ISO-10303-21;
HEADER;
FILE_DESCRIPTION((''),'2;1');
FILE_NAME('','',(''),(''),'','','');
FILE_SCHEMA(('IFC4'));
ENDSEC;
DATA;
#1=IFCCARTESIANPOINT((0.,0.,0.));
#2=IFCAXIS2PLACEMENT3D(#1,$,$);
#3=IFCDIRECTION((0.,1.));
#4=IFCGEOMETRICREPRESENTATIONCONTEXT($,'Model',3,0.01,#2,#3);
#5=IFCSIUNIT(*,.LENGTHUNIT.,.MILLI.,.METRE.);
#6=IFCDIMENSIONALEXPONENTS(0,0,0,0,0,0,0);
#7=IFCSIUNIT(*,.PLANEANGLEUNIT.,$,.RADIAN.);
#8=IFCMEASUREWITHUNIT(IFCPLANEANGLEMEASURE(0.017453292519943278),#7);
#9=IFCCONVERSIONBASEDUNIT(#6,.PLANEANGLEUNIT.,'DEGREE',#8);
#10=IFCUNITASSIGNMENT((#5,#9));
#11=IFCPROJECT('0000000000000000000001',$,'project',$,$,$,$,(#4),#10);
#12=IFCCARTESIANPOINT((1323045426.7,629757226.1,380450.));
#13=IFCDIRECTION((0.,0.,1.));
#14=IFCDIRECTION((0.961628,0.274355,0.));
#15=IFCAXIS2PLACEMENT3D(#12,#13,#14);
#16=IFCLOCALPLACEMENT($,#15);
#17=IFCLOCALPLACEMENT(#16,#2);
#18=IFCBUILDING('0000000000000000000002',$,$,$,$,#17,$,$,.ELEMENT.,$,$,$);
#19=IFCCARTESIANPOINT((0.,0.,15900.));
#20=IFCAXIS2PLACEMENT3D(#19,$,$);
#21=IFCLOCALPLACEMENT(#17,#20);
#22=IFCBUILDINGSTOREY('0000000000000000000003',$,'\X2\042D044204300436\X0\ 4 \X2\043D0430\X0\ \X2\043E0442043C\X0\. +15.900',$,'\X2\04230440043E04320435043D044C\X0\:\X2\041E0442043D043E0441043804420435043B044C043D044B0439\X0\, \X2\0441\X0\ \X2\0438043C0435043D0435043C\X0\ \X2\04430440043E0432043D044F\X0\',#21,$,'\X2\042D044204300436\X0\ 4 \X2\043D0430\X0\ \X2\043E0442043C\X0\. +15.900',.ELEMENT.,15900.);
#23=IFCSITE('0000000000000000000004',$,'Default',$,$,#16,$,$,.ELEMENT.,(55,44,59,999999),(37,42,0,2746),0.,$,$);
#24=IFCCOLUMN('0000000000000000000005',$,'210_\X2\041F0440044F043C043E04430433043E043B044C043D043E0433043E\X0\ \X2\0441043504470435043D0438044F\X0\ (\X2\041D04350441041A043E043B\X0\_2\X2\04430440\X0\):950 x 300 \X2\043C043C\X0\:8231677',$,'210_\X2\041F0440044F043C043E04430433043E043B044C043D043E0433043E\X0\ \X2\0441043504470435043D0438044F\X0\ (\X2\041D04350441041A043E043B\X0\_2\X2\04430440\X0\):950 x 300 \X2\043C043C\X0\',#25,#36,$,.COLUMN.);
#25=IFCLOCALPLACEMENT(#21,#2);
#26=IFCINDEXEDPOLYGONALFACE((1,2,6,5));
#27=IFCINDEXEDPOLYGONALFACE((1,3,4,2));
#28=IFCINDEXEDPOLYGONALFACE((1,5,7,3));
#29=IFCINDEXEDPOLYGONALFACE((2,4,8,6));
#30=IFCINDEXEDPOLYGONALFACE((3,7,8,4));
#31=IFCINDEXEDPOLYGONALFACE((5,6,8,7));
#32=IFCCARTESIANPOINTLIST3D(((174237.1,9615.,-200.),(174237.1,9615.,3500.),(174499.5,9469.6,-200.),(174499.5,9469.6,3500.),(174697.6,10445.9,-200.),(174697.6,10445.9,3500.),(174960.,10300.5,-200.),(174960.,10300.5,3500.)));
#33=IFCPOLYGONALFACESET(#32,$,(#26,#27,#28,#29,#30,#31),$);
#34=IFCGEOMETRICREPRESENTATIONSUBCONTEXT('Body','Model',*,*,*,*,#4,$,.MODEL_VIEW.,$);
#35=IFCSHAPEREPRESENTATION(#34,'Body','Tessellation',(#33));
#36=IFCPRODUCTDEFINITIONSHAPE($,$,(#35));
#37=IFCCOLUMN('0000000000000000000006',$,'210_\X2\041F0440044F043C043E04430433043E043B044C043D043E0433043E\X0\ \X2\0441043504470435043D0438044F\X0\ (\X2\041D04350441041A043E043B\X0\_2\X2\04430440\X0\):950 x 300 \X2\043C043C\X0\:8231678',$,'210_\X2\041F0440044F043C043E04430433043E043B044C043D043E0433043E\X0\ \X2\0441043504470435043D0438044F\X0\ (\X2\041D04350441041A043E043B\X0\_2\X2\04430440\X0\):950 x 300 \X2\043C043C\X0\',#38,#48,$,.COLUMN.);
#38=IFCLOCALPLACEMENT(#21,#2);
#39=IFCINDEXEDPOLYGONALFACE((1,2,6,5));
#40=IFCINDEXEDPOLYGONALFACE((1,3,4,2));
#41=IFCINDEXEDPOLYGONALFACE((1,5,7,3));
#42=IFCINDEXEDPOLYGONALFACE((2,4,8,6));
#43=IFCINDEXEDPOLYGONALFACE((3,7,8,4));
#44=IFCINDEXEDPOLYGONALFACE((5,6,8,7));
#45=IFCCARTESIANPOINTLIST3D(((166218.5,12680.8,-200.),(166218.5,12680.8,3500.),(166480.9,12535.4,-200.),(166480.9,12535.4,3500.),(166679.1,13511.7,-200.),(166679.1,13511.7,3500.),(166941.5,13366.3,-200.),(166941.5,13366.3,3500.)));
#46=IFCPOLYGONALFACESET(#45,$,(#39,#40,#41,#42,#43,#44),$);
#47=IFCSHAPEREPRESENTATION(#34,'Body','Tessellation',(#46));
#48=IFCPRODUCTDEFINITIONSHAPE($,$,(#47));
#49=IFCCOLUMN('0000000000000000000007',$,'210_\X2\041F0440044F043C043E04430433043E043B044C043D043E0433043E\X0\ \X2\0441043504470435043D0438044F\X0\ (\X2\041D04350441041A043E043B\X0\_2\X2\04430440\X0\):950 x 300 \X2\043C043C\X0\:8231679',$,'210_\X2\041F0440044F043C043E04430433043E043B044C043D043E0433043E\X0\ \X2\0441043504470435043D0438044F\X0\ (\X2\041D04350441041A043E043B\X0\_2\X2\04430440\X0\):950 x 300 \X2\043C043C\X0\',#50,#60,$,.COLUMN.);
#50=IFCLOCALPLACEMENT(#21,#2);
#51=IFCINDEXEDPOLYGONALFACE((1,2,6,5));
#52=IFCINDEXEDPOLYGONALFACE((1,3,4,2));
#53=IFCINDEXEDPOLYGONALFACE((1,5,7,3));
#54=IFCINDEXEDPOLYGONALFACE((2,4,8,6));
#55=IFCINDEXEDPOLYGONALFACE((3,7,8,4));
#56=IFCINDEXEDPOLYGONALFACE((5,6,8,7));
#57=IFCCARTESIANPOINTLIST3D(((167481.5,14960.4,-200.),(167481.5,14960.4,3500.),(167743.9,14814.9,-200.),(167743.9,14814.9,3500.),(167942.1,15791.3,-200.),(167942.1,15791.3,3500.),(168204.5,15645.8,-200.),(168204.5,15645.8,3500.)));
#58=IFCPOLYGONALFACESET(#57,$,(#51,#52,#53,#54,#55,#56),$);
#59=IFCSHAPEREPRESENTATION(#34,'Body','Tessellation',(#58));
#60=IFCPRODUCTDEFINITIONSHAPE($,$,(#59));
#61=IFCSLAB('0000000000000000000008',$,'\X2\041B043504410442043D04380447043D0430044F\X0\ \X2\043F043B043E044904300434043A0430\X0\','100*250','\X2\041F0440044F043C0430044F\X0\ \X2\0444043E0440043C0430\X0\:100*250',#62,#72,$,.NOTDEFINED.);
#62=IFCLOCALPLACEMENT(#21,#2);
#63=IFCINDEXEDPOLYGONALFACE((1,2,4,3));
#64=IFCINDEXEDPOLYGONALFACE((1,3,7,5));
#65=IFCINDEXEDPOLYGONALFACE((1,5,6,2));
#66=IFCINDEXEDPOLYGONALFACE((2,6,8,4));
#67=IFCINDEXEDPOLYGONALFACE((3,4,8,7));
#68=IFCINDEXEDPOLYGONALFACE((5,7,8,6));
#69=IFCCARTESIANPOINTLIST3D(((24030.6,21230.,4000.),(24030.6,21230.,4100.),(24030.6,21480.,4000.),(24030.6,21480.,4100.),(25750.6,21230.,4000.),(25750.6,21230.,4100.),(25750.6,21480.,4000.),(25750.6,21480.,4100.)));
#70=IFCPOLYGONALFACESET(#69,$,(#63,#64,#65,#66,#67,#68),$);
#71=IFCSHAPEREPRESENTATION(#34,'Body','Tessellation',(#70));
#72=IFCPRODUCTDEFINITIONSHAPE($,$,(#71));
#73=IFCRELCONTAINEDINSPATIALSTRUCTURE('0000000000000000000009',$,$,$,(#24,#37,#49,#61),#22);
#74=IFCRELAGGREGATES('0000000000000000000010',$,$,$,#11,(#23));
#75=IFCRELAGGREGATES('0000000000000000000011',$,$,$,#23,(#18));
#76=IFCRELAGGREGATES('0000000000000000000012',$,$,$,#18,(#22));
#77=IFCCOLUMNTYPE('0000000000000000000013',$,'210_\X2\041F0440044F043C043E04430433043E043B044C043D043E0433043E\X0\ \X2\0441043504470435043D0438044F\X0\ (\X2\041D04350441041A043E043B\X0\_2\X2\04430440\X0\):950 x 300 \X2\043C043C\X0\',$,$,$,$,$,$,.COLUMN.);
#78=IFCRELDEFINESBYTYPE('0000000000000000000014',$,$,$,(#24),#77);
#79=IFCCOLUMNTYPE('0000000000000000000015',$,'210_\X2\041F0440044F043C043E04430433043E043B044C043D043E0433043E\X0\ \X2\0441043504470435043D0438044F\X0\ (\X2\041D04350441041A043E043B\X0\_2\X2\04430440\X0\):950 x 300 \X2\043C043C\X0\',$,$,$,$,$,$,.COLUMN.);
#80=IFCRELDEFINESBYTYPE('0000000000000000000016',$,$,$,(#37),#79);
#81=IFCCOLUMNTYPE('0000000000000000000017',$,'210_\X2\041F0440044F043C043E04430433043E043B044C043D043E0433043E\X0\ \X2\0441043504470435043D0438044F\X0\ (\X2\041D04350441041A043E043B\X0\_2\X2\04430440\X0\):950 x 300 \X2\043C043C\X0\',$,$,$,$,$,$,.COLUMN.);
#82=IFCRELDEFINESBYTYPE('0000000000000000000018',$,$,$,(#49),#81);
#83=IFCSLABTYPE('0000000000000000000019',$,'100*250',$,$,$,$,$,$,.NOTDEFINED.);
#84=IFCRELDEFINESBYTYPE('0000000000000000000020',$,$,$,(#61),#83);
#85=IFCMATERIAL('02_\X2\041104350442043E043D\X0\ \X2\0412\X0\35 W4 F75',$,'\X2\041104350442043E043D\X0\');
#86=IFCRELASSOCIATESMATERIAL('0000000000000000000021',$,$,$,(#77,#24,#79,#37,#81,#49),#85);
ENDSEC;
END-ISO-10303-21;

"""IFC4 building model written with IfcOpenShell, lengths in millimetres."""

from ifc_helpers import new_model, entity, si_unit, converted_unit, direction, frame, origin, place, context, subcontext, project, spatial, indexed_curve, outline, extrude, source, transform, mapped, material, type_object, type_shapes, element, save


model = new_model("IFC4")

# Units and contexts
model_context = context("Model", 3, precision=0.01, world=origin(), true_north=direction((0.0, 1.0)))
body_context = subcontext(model_context, "Body", "Model", "MODEL_VIEW")
ifc_project = project(units=[si_unit("LENGTHUNIT", "METRE", prefix="MILLI"), converted_unit("PLANEANGLEUNIT", "DEGREE", entity("IfcPlaneAngleMeasure", 0.017453292519943278), si_unit("PLANEANGLEUNIT", "RADIAN"), dimensions=[0, 0, 0, 0, 0, 0, 0])], contexts=[model_context])

# Site, building, storey
site_placement = place(None, frame((1323045426.7, 629757226.1, 380450.0), z_axis=(0.0, 0.0, 1.0), x_axis=(0.961628, 0.274355, 0.0)))
site = spatial("IfcSite", under=ifc_project, at=site_placement, Name="Default", CompositionType="ELEMENT", RefLatitude=(55, 44, 59, 999999), RefLongitude=(37, 42, 0, 2746), RefElevation=0.0)
building_placement = place(site_placement, origin())
building = spatial("IfcBuilding", under=site, at=building_placement, CompositionType="ELEMENT")
storey_placement = place(building_placement, frame((0.0, 0.0, 15900.0)))
storey = spatial("IfcBuildingStorey", under=building, at=storey_placement, Name="Этаж 4 на отм. +15.900", ObjectType="Уровень:Относительный, с именем уровня", LongName="Этаж 4 на отм. +15.900", CompositionType="ELEMENT", Elevation=15900.0)

# Columns
ifc_material_1 = material(Name="02_Бетон В35 W4 F75", Category="Бетон")
column_type_1 = type_object("IfcColumnType", Name="210_Прямоугольного сечения (НесКол_2ур):950 x 300 мм", PredefinedType="COLUMN", material=ifc_material_1)
shared_shape_1 = source(origin(), body_context, "Body", "SweptSolid", [
    extrude(outline(indexed_curve([(-150.0, -475.0), (150.0, -475.0), (150.0, 475.0), (-150.0, 475.0), (-150.0, -475.0)], self_intersect=False)), frame((174598.6, 9957.8, 15700.0), z_axis=(0.0, 0.0, 1.0), x_axis=(-0.87462, 0.48481, 0.0)), (0.0, 0.0, 1.0), 3700.0),
])
type_shapes(column_type_1, [shared_shape_1])
column_1_placement = place(storey_placement, frame((0.0, 0.0, -15900.0)))
element("IfcColumn", 1, at=column_1_placement, inside=storey, type_object=column_type_1, material=ifc_material_1, Name="210_Прямоугольного сечения (НесКол_2ур):950 x 300 мм:8231677", ObjectType="210_Прямоугольного сечения (НесКол_2ур):950 x 300 мм", PredefinedType="COLUMN", context=body_context, shape_type="MappedRepresentation", body=[
    mapped(shared_shape_1, transform((0.0, 0.0, 0.0), scale=1.0)),
])
column_type_2 = type_object("IfcColumnType", Name="210_Прямоугольного сечения (НесКол_2ур):950 x 300 мм", PredefinedType="COLUMN", material=ifc_material_1)
shared_shape_2 = source(origin(), body_context, "Body", "SweptSolid", [
    extrude(outline(indexed_curve([(-150.0, -475.0), (150.0, -475.0), (150.0, 475.0), (-150.0, 475.0), (-150.0, -475.0)], self_intersect=False)), frame((166580.0, 13023.6, 15700.0), z_axis=(0.0, 0.0, 1.0), x_axis=(-0.87462, 0.48481, 0.0)), (0.0, 0.0, 1.0), 3700.0),
])
type_shapes(column_type_2, [shared_shape_2])
column_2_placement = place(storey_placement, frame((0.0, 0.0, -15900.0)))
element("IfcColumn", 2, at=column_2_placement, inside=storey, type_object=column_type_2, material=ifc_material_1, Name="210_Прямоугольного сечения (НесКол_2ур):950 x 300 мм:8231678", ObjectType="210_Прямоугольного сечения (НесКол_2ур):950 x 300 мм", PredefinedType="COLUMN", context=body_context, shape_type="MappedRepresentation", body=[
    mapped(shared_shape_2, transform((0.0, 0.0, 0.0), scale=1.0)),
])
column_type_3 = type_object("IfcColumnType", Name="210_Прямоугольного сечения (НесКол_2ур):950 x 300 мм", PredefinedType="COLUMN", material=ifc_material_1)
shared_shape_3 = source(origin(), body_context, "Body", "SweptSolid", [
    extrude(outline(indexed_curve([(-150.0, -475.0), (150.0, -475.0), (150.0, 475.0), (-150.0, 475.0), (-150.0, -475.0)], self_intersect=False)), frame((167843.0, 15303.1, 15700.0), z_axis=(0.0, 0.0, 1.0), x_axis=(-0.87462, 0.48481, 0.0)), (0.0, 0.0, 1.0), 3700.0),
])
type_shapes(column_type_3, [shared_shape_3])
column_3_placement = place(storey_placement, frame((0.0, 0.0, -15900.0)))
element("IfcColumn", 3, at=column_3_placement, inside=storey, type_object=column_type_3, material=ifc_material_1, Name="210_Прямоугольного сечения (НесКол_2ур):950 x 300 мм:8231679", ObjectType="210_Прямоугольного сечения (НесКол_2ур):950 x 300 мм", PredefinedType="COLUMN", context=body_context, shape_type="MappedRepresentation", body=[
    mapped(shared_shape_3, transform((0.0, 0.0, 0.0), scale=1.0)),
])

# Slab
slab_type_1 = type_object("IfcSlabType", Name="100*250", PredefinedType="NOTDEFINED")
slab_1_placement = place(storey_placement, origin())
element("IfcSlab", 4, at=slab_1_placement, inside=storey, type_object=slab_type_1, Name="Лестничная площадка", Description="100*250", ObjectType="Прямая форма:100*250", PredefinedType="NOTDEFINED", context=body_context, shape_type="SweptSolid", body=[
    extrude(outline(indexed_curve([(-860.0, -125.0), (860.0, -125.0), (860.0, 125.0), (-860.0, 125.0), (-860.0, -125.0)], self_intersect=False)), frame((24890.6, 21355.0, 4000.0)), (0.0, 0.0, 1.0), 100.0),
])

save(model, "model.ifc")
